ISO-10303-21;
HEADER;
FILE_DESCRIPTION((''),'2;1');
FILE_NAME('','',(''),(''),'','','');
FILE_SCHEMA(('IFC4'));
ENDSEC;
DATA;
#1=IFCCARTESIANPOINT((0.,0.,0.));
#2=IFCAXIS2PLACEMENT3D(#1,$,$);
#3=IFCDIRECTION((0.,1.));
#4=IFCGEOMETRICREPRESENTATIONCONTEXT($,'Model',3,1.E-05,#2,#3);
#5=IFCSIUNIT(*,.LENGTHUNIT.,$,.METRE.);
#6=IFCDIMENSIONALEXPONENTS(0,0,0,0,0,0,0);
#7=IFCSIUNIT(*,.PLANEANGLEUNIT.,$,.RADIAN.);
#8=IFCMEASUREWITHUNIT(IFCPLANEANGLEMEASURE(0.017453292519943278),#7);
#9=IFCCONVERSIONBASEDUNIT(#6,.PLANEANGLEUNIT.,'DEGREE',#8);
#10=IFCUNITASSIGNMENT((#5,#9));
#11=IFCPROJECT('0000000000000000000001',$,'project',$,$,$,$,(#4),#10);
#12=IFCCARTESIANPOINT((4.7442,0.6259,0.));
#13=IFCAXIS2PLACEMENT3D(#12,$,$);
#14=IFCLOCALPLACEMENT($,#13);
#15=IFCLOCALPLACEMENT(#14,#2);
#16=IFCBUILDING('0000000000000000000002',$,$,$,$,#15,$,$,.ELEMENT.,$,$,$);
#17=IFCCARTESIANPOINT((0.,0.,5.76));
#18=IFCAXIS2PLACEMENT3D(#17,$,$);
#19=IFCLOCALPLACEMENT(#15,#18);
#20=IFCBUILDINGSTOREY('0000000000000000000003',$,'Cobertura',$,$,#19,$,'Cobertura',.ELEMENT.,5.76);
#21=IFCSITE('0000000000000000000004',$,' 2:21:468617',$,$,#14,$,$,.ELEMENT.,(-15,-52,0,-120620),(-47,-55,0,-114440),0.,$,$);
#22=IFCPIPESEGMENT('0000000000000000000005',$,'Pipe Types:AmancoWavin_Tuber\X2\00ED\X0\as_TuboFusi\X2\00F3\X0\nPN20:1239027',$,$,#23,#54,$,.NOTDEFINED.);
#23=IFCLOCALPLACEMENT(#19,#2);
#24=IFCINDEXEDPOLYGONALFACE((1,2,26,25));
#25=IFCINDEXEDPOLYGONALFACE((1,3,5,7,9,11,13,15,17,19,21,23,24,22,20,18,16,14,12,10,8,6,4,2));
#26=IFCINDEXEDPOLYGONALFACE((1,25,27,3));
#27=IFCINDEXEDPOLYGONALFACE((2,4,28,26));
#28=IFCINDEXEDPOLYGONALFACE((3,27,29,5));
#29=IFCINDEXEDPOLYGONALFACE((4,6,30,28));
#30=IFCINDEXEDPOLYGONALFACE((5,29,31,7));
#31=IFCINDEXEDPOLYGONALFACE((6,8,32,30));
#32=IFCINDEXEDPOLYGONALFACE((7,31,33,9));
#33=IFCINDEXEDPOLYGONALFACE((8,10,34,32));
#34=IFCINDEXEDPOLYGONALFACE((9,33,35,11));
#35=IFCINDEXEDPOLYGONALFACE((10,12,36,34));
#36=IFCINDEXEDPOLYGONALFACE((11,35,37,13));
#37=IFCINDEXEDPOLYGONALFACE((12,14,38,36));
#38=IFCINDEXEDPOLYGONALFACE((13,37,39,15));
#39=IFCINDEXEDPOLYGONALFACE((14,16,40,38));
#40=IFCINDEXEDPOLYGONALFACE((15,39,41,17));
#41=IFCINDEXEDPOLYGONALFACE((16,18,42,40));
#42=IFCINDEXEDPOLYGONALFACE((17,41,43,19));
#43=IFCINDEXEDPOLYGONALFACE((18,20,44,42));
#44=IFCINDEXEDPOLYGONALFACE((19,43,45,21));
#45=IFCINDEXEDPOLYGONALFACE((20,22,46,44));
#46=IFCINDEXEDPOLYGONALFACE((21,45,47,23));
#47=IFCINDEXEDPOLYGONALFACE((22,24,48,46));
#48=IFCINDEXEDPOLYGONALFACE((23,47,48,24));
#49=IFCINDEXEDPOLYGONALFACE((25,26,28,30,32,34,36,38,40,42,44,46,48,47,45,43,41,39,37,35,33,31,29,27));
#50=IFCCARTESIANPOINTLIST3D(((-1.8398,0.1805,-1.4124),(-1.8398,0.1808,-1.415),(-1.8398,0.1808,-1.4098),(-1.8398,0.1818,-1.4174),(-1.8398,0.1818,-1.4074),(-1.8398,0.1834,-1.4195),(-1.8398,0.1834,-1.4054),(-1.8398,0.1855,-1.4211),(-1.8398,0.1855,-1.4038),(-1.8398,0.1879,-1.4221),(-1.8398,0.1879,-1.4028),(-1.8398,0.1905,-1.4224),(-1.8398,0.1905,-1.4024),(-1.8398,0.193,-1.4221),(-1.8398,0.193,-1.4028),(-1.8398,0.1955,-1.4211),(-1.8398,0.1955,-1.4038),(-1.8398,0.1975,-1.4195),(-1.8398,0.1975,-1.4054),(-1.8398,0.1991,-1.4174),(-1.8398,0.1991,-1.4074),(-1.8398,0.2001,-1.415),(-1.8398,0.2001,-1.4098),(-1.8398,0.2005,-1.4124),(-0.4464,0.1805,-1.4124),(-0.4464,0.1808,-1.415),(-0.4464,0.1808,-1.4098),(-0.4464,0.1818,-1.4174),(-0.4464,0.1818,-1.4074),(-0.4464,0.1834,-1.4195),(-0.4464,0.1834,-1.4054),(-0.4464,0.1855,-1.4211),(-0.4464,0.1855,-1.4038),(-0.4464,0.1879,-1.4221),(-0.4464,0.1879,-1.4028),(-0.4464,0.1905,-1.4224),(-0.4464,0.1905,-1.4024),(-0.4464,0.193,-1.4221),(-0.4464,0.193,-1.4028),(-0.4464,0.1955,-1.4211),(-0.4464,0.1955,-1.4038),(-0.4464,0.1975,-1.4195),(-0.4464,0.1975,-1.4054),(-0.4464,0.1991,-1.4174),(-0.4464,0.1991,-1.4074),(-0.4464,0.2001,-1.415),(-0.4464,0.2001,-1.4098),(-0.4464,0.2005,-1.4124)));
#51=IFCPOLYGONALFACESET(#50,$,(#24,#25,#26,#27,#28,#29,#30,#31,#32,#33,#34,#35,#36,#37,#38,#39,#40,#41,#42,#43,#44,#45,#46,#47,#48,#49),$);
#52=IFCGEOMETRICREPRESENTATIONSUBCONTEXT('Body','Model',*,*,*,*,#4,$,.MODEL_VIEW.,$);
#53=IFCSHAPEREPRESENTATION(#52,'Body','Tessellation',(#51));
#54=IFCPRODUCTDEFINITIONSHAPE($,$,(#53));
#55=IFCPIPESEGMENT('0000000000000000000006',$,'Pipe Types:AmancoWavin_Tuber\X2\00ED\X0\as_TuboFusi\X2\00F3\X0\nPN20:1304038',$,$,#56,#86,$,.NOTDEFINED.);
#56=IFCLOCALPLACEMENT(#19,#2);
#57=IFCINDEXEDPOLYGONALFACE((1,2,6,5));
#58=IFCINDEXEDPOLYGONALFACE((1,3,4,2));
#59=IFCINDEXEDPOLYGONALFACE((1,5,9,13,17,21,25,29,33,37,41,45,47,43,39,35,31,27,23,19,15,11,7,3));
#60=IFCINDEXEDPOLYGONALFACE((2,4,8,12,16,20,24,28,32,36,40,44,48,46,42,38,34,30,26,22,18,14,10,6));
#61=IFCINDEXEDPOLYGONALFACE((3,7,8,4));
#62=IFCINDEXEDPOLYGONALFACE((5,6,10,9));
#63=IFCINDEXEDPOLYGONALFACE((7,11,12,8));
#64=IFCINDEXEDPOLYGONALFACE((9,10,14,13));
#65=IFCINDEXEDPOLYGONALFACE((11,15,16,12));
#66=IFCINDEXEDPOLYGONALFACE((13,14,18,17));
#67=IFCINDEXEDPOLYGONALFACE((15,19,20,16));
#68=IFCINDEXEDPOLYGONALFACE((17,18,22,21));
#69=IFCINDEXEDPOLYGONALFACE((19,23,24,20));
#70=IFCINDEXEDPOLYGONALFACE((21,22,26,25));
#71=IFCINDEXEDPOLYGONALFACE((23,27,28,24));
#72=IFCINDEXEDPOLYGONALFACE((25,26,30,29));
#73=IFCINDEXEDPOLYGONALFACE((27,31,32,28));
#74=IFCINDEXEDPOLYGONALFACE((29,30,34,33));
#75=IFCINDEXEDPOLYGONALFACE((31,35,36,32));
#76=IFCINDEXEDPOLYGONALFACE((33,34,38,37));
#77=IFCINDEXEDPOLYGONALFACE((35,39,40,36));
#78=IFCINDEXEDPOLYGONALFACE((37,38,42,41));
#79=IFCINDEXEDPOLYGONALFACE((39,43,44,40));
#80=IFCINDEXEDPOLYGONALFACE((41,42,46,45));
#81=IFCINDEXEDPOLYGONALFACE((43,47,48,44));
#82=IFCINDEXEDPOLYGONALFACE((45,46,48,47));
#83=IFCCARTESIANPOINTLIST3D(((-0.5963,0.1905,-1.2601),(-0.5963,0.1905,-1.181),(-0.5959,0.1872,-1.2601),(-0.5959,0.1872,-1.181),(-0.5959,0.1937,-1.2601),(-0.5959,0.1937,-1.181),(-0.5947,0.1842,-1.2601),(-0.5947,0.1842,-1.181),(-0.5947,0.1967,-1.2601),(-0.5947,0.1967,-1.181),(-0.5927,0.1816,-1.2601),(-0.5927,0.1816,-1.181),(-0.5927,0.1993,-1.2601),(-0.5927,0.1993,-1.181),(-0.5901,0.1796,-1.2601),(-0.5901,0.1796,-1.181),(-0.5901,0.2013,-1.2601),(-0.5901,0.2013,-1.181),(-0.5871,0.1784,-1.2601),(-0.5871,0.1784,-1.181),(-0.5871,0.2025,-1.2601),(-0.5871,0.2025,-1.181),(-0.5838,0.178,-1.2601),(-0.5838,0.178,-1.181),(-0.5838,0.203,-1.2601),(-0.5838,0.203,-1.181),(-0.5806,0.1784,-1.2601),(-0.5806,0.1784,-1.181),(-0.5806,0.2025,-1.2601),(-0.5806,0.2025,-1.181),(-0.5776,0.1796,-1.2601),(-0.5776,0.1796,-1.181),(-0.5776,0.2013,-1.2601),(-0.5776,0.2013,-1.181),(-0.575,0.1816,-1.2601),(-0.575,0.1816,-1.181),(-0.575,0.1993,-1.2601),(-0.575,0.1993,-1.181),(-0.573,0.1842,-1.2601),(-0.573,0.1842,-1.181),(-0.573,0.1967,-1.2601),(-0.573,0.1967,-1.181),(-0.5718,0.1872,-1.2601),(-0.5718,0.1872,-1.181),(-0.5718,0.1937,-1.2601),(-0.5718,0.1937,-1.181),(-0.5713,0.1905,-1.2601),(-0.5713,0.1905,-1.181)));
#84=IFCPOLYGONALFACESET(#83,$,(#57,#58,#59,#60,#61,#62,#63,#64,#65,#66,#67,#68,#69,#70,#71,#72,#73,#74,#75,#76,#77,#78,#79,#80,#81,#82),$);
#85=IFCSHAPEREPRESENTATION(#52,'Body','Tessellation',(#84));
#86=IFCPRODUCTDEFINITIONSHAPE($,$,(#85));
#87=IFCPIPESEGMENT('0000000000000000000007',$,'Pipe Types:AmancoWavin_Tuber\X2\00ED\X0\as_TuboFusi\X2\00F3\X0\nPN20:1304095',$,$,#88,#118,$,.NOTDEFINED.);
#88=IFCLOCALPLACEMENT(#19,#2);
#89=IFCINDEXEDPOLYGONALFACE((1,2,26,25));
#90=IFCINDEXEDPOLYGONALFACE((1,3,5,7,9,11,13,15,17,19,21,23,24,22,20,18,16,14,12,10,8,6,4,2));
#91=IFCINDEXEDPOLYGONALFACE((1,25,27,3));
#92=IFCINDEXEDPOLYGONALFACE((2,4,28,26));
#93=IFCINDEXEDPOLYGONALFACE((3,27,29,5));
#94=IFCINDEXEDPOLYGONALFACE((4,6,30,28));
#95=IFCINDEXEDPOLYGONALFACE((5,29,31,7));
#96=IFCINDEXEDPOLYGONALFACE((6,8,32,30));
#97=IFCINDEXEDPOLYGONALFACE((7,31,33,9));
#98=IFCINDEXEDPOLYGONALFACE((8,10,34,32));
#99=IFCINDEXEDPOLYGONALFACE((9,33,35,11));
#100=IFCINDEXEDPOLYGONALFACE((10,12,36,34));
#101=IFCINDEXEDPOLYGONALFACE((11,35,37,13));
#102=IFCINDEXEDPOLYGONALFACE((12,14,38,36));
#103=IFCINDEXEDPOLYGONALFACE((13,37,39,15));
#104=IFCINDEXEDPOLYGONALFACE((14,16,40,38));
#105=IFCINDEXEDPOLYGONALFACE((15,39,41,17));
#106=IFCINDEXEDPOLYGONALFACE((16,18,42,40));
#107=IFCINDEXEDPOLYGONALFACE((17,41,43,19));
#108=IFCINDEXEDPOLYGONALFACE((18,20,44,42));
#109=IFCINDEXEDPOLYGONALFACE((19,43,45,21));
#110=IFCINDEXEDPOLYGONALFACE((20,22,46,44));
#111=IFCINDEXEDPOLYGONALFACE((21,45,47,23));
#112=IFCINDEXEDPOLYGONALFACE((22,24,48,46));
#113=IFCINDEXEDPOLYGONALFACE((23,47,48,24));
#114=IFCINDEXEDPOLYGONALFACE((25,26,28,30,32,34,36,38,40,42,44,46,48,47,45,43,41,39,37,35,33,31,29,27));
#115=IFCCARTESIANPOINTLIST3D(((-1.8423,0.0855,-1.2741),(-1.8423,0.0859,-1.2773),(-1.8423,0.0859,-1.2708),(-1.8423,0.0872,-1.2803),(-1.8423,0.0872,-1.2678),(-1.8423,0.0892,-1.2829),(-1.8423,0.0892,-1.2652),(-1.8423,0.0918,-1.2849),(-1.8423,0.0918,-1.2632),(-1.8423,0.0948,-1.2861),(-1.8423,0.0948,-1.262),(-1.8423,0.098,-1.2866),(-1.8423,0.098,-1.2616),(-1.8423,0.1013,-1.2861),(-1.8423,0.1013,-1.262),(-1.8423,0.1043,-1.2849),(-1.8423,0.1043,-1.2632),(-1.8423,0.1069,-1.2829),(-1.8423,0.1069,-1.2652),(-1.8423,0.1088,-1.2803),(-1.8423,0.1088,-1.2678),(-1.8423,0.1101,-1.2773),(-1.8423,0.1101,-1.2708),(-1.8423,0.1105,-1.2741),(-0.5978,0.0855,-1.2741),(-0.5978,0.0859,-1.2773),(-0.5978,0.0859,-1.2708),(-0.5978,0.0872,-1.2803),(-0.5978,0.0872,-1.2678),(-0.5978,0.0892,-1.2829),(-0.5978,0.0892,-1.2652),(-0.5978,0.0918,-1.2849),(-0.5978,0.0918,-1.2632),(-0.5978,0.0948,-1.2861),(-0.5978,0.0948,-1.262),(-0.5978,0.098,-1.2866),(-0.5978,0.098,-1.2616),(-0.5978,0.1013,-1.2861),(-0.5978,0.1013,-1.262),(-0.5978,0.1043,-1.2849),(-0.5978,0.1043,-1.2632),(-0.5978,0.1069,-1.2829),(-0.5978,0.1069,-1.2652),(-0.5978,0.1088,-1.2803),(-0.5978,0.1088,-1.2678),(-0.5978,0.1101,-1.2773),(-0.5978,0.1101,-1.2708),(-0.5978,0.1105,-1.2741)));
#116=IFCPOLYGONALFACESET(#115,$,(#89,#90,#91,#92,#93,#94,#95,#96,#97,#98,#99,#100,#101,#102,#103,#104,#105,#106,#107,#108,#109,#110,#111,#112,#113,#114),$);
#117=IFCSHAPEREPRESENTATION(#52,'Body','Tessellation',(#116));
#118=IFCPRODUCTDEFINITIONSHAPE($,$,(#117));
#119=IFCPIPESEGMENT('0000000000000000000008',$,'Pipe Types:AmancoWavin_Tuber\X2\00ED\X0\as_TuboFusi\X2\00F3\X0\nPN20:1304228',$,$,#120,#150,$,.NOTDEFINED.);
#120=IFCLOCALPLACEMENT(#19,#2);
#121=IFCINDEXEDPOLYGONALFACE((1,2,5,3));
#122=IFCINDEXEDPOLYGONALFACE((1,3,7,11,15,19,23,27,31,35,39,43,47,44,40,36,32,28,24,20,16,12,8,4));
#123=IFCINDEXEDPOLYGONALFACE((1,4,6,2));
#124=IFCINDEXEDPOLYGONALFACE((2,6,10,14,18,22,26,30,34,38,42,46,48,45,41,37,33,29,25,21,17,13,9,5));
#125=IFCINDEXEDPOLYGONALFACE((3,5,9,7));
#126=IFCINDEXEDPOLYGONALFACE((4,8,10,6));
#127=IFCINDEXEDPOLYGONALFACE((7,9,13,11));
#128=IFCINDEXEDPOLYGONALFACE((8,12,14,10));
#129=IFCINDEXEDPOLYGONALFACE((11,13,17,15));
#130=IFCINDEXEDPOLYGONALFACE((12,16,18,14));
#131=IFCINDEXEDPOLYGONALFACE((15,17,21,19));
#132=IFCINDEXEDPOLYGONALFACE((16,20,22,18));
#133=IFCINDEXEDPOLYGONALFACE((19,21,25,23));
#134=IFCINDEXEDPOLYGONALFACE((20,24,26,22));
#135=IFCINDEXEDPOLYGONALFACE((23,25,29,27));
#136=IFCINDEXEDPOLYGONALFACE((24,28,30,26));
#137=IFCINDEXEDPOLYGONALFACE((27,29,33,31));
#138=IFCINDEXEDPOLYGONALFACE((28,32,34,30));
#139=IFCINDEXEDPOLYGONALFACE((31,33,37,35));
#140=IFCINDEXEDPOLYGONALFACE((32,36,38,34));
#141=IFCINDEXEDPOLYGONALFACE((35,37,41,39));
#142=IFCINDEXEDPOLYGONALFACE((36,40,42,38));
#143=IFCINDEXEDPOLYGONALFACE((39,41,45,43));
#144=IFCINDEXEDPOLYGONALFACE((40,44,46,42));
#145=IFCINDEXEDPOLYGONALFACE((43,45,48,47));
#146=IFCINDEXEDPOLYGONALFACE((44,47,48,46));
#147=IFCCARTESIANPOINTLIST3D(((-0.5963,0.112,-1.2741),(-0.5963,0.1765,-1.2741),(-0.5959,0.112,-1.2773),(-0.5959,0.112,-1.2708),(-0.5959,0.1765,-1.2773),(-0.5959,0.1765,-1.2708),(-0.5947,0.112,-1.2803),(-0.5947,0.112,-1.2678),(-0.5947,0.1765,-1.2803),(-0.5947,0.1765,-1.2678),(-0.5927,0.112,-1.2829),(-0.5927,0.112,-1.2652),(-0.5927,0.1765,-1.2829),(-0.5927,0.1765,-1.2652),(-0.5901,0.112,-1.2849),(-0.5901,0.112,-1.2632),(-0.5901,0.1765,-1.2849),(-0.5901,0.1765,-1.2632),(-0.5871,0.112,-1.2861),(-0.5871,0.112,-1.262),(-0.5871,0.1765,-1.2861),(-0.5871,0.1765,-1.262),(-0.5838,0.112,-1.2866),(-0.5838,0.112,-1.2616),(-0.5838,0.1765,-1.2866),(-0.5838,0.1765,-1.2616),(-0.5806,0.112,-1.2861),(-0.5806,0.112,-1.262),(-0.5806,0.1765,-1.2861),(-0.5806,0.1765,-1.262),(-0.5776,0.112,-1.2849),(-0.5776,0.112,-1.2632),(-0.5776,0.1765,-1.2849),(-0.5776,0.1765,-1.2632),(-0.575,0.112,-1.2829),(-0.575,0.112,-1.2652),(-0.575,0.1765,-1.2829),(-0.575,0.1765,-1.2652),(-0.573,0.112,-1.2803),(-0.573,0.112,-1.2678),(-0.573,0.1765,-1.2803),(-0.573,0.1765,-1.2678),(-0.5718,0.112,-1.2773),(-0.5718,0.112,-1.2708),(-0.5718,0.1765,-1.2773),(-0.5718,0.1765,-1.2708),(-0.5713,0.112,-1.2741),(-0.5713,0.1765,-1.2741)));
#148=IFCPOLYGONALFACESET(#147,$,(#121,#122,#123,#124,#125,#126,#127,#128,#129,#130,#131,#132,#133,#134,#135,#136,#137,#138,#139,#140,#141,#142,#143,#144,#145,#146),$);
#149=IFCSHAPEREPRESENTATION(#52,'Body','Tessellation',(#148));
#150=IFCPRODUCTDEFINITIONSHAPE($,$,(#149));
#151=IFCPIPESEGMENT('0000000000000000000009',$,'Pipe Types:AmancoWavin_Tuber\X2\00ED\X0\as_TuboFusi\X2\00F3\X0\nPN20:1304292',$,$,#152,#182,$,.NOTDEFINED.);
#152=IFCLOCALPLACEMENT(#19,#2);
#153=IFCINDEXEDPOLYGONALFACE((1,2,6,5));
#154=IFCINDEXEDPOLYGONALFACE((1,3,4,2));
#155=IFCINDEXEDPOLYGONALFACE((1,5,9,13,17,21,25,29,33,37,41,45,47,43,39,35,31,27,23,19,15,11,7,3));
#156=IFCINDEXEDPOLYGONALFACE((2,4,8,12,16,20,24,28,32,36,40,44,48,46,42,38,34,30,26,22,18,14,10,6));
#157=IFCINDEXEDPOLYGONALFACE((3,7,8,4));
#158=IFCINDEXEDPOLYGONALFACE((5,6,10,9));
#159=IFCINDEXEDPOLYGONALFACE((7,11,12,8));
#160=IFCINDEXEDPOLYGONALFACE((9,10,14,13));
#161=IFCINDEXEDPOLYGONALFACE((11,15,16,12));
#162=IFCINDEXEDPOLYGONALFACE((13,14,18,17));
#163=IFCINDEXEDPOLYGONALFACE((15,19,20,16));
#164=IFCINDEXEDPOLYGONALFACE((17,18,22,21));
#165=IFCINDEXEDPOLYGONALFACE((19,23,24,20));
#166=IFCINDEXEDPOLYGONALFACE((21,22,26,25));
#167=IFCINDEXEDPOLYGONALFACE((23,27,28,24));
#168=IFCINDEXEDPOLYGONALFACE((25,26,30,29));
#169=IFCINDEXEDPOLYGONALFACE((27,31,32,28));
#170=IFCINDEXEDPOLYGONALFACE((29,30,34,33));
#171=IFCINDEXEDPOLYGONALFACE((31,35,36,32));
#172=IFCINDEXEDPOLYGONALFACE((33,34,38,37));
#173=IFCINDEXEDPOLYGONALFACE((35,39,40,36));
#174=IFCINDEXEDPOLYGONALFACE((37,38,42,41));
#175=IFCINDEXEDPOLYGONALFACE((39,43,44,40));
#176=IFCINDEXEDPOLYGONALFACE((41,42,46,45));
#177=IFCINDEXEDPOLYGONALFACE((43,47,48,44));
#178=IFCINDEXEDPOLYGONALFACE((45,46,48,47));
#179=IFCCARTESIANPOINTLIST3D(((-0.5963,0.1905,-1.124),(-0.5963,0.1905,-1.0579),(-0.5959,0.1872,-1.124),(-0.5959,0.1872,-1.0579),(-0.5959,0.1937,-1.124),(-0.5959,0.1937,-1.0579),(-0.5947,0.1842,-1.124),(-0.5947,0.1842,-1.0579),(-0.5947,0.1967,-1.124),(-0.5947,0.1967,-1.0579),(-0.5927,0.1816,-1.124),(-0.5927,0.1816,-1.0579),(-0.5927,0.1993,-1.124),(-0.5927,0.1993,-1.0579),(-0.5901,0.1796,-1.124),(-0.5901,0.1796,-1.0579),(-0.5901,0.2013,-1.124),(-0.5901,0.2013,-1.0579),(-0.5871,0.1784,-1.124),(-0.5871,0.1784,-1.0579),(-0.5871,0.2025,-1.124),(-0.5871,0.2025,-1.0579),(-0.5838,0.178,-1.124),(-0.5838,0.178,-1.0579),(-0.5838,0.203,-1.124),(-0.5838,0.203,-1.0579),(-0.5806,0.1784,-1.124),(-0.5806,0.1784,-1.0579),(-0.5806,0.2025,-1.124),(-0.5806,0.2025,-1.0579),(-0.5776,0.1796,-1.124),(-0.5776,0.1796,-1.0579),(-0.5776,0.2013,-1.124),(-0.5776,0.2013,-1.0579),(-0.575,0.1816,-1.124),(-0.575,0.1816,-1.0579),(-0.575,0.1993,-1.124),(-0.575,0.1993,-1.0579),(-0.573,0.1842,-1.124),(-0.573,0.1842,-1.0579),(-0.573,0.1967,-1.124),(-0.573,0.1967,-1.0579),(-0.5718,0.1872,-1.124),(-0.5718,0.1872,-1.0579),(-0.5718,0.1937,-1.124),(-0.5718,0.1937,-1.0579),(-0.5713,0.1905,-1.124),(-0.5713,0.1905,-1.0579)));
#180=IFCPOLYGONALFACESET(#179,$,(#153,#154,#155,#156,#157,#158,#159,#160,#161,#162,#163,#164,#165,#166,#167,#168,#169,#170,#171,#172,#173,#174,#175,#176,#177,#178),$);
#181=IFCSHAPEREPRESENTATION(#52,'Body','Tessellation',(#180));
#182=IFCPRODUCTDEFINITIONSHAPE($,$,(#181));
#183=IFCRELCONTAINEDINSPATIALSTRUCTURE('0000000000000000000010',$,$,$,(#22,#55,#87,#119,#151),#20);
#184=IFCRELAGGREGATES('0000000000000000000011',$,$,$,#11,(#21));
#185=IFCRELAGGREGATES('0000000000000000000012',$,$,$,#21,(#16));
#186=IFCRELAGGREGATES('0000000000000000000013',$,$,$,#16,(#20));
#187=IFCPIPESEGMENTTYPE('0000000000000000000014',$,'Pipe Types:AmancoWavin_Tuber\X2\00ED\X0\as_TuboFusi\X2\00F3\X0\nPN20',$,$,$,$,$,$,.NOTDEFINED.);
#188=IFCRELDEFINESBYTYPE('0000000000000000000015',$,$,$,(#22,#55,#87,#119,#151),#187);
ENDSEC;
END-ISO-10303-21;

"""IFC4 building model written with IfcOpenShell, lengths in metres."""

from ifc_helpers import new_model, entity, si_unit, converted_unit, direction, frame, origin, place, context, subcontext, project, spatial, arc, indexed_curve, outline, extrude, type_object, element, save


model = new_model("IFC4")

# Units and contexts
model_context = context("Model", 3, precision=1e-05, world=origin(), true_north=direction((0.0, 1.0)))
body_context = subcontext(model_context, "Body", "Model", "MODEL_VIEW")
ifc_project = project(units=[si_unit("LENGTHUNIT", "METRE"), converted_unit("PLANEANGLEUNIT", "DEGREE", entity("IfcPlaneAngleMeasure", 0.017453292519943278), si_unit("PLANEANGLEUNIT", "RADIAN"), dimensions=[0, 0, 0, 0, 0, 0, 0])], contexts=[model_context])

# Site, building, storey
site_placement = place(None, frame((4.7442, 0.6259, 0.0)))
site = spatial("IfcSite", under=ifc_project, at=site_placement, Name=" 2:21:468617", CompositionType="ELEMENT", RefLatitude=(-15, -52, 0, -120620), RefLongitude=(-47, -55, 0, -114440), RefElevation=0.0)
building_placement = place(site_placement, origin())
building = spatial("IfcBuilding", under=site, at=building_placement, CompositionType="ELEMENT")
storey_placement = place(building_placement, frame((0.0, 0.0, 5.76)))
storey = spatial("IfcBuildingStorey", under=building, at=storey_placement, Name="Cobertura", LongName="Cobertura", CompositionType="ELEMENT", Elevation=5.76)

# Pipe segments
pipe_segment_type = type_object("IfcPipeSegmentType", Name="Pipe Types:AmancoWavin_Tuberías_TuboFusiónPN20", PredefinedType="NOTDEFINED")
pipe_segment_1_placement = place(storey_placement, origin())
element("IfcPipeSegment", 1, at=pipe_segment_1_placement, inside=storey, type_object=pipe_segment_type, Name="Pipe Types:AmancoWavin_Tuberías_TuboFusiónPN20:1239027", PredefinedType="NOTDEFINED", context=body_context, shape_type="SweptSolid", body=[
    extrude(outline(indexed_curve([(0.01, 0.0), (0.0071, 0.0071), (0.0, 0.01), (-0.0071, 0.0071), (-0.01, 0.0), (-0.0071, -0.0071), (0.0, -0.01), (0.0071, -0.0071)], segments=[arc(1, 2, 3), arc(3, 4, 5), arc(5, 6, 7), arc(7, 8, 1)], self_intersect=False)), frame((-1.8398, 0.1905, -1.4124), z_axis=(1.0, 0.0, 0.0), x_axis=(0.0, 1.0, 0.0)), (0.0, 0.0, 1.0), 1.3934),
])
pipe_segment_2_placement = place(storey_placement, origin())
element("IfcPipeSegment", 2, at=pipe_segment_2_placement, inside=storey, type_object=pipe_segment_type, Name="Pipe Types:AmancoWavin_Tuberías_TuboFusiónPN20:1304038", PredefinedType="NOTDEFINED", context=body_context, shape_type="SweptSolid", body=[
    extrude(outline(indexed_curve([(0.0125, 0.0), (0.0088, 0.0088), (0.0, 0.0125), (-0.0088, 0.0088), (-0.0125, 0.0), (-0.0088, -0.0088), (0.0, -0.0125), (0.0088, -0.0088)], segments=[arc(1, 2, 3), arc(3, 4, 5), arc(5, 6, 7), arc(7, 8, 1)], self_intersect=False)), frame((-0.5838, 0.1905, -1.2601)), (0.0, 0.0, 1.0), 0.0791),
])
pipe_segment_3_placement = place(storey_placement, origin())
element("IfcPipeSegment", 3, at=pipe_segment_3_placement, inside=storey, type_object=pipe_segment_type, Name="Pipe Types:AmancoWavin_Tuberías_TuboFusiónPN20:1304095", PredefinedType="NOTDEFINED", context=body_context, shape_type="SweptSolid", body=[
    extrude(outline(indexed_curve([(0.0125, 0.0), (0.0088, 0.0088), (0.0, 0.0125), (-0.0088, 0.0088), (-0.0125, 0.0), (-0.0088, -0.0088), (0.0, -0.0125), (0.0088, -0.0088)], segments=[arc(1, 2, 3), arc(3, 4, 5), arc(5, 6, 7), arc(7, 8, 1)], self_intersect=False)), frame((-1.8423, 0.098, -1.2741), z_axis=(1.0, 0.0, 0.0), x_axis=(0.0, 1.0, 0.0)), (0.0, 0.0, 1.0), 1.2444),
])
pipe_segment_4_placement = place(storey_placement, origin())
element("IfcPipeSegment", 4, at=pipe_segment_4_placement, inside=storey, type_object=pipe_segment_type, Name="Pipe Types:AmancoWavin_Tuberías_TuboFusiónPN20:1304228", PredefinedType="NOTDEFINED", context=body_context, shape_type="SweptSolid", body=[
    extrude(outline(indexed_curve([(0.0125, 0.0), (0.0088, 0.0088), (0.0, 0.0125), (-0.0088, 0.0088), (-0.0125, 0.0), (-0.0088, -0.0088), (0.0, -0.0125), (0.0088, -0.0088)], segments=[arc(1, 2, 3), arc(3, 4, 5), arc(5, 6, 7), arc(7, 8, 1)], self_intersect=False)), frame((-0.5838, 0.112, -1.2741), z_axis=(0.0, 1.0, 0.0), x_axis=(-1.0, 0.0, 0.0)), (0.0, 0.0, 1.0), 0.0644),
])
pipe_segment_5_placement = place(storey_placement, origin())
element("IfcPipeSegment", 5, at=pipe_segment_5_placement, inside=storey, type_object=pipe_segment_type, Name="Pipe Types:AmancoWavin_Tuberías_TuboFusiónPN20:1304292", PredefinedType="NOTDEFINED", context=body_context, shape_type="SweptSolid", body=[
    extrude(outline(indexed_curve([(0.0125, 0.0), (0.0088, 0.0088), (0.0, 0.0125), (-0.0088, 0.0088), (-0.0125, 0.0), (-0.0088, -0.0088), (0.0, -0.0125), (0.0088, -0.0088)], segments=[arc(1, 2, 3), arc(3, 4, 5), arc(5, 6, 7), arc(7, 8, 1)], self_intersect=False)), frame((-0.5838, 0.1905, -1.124)), (0.0, 0.0, 1.0), 0.0661),
])

save(model, "model.ifc")
